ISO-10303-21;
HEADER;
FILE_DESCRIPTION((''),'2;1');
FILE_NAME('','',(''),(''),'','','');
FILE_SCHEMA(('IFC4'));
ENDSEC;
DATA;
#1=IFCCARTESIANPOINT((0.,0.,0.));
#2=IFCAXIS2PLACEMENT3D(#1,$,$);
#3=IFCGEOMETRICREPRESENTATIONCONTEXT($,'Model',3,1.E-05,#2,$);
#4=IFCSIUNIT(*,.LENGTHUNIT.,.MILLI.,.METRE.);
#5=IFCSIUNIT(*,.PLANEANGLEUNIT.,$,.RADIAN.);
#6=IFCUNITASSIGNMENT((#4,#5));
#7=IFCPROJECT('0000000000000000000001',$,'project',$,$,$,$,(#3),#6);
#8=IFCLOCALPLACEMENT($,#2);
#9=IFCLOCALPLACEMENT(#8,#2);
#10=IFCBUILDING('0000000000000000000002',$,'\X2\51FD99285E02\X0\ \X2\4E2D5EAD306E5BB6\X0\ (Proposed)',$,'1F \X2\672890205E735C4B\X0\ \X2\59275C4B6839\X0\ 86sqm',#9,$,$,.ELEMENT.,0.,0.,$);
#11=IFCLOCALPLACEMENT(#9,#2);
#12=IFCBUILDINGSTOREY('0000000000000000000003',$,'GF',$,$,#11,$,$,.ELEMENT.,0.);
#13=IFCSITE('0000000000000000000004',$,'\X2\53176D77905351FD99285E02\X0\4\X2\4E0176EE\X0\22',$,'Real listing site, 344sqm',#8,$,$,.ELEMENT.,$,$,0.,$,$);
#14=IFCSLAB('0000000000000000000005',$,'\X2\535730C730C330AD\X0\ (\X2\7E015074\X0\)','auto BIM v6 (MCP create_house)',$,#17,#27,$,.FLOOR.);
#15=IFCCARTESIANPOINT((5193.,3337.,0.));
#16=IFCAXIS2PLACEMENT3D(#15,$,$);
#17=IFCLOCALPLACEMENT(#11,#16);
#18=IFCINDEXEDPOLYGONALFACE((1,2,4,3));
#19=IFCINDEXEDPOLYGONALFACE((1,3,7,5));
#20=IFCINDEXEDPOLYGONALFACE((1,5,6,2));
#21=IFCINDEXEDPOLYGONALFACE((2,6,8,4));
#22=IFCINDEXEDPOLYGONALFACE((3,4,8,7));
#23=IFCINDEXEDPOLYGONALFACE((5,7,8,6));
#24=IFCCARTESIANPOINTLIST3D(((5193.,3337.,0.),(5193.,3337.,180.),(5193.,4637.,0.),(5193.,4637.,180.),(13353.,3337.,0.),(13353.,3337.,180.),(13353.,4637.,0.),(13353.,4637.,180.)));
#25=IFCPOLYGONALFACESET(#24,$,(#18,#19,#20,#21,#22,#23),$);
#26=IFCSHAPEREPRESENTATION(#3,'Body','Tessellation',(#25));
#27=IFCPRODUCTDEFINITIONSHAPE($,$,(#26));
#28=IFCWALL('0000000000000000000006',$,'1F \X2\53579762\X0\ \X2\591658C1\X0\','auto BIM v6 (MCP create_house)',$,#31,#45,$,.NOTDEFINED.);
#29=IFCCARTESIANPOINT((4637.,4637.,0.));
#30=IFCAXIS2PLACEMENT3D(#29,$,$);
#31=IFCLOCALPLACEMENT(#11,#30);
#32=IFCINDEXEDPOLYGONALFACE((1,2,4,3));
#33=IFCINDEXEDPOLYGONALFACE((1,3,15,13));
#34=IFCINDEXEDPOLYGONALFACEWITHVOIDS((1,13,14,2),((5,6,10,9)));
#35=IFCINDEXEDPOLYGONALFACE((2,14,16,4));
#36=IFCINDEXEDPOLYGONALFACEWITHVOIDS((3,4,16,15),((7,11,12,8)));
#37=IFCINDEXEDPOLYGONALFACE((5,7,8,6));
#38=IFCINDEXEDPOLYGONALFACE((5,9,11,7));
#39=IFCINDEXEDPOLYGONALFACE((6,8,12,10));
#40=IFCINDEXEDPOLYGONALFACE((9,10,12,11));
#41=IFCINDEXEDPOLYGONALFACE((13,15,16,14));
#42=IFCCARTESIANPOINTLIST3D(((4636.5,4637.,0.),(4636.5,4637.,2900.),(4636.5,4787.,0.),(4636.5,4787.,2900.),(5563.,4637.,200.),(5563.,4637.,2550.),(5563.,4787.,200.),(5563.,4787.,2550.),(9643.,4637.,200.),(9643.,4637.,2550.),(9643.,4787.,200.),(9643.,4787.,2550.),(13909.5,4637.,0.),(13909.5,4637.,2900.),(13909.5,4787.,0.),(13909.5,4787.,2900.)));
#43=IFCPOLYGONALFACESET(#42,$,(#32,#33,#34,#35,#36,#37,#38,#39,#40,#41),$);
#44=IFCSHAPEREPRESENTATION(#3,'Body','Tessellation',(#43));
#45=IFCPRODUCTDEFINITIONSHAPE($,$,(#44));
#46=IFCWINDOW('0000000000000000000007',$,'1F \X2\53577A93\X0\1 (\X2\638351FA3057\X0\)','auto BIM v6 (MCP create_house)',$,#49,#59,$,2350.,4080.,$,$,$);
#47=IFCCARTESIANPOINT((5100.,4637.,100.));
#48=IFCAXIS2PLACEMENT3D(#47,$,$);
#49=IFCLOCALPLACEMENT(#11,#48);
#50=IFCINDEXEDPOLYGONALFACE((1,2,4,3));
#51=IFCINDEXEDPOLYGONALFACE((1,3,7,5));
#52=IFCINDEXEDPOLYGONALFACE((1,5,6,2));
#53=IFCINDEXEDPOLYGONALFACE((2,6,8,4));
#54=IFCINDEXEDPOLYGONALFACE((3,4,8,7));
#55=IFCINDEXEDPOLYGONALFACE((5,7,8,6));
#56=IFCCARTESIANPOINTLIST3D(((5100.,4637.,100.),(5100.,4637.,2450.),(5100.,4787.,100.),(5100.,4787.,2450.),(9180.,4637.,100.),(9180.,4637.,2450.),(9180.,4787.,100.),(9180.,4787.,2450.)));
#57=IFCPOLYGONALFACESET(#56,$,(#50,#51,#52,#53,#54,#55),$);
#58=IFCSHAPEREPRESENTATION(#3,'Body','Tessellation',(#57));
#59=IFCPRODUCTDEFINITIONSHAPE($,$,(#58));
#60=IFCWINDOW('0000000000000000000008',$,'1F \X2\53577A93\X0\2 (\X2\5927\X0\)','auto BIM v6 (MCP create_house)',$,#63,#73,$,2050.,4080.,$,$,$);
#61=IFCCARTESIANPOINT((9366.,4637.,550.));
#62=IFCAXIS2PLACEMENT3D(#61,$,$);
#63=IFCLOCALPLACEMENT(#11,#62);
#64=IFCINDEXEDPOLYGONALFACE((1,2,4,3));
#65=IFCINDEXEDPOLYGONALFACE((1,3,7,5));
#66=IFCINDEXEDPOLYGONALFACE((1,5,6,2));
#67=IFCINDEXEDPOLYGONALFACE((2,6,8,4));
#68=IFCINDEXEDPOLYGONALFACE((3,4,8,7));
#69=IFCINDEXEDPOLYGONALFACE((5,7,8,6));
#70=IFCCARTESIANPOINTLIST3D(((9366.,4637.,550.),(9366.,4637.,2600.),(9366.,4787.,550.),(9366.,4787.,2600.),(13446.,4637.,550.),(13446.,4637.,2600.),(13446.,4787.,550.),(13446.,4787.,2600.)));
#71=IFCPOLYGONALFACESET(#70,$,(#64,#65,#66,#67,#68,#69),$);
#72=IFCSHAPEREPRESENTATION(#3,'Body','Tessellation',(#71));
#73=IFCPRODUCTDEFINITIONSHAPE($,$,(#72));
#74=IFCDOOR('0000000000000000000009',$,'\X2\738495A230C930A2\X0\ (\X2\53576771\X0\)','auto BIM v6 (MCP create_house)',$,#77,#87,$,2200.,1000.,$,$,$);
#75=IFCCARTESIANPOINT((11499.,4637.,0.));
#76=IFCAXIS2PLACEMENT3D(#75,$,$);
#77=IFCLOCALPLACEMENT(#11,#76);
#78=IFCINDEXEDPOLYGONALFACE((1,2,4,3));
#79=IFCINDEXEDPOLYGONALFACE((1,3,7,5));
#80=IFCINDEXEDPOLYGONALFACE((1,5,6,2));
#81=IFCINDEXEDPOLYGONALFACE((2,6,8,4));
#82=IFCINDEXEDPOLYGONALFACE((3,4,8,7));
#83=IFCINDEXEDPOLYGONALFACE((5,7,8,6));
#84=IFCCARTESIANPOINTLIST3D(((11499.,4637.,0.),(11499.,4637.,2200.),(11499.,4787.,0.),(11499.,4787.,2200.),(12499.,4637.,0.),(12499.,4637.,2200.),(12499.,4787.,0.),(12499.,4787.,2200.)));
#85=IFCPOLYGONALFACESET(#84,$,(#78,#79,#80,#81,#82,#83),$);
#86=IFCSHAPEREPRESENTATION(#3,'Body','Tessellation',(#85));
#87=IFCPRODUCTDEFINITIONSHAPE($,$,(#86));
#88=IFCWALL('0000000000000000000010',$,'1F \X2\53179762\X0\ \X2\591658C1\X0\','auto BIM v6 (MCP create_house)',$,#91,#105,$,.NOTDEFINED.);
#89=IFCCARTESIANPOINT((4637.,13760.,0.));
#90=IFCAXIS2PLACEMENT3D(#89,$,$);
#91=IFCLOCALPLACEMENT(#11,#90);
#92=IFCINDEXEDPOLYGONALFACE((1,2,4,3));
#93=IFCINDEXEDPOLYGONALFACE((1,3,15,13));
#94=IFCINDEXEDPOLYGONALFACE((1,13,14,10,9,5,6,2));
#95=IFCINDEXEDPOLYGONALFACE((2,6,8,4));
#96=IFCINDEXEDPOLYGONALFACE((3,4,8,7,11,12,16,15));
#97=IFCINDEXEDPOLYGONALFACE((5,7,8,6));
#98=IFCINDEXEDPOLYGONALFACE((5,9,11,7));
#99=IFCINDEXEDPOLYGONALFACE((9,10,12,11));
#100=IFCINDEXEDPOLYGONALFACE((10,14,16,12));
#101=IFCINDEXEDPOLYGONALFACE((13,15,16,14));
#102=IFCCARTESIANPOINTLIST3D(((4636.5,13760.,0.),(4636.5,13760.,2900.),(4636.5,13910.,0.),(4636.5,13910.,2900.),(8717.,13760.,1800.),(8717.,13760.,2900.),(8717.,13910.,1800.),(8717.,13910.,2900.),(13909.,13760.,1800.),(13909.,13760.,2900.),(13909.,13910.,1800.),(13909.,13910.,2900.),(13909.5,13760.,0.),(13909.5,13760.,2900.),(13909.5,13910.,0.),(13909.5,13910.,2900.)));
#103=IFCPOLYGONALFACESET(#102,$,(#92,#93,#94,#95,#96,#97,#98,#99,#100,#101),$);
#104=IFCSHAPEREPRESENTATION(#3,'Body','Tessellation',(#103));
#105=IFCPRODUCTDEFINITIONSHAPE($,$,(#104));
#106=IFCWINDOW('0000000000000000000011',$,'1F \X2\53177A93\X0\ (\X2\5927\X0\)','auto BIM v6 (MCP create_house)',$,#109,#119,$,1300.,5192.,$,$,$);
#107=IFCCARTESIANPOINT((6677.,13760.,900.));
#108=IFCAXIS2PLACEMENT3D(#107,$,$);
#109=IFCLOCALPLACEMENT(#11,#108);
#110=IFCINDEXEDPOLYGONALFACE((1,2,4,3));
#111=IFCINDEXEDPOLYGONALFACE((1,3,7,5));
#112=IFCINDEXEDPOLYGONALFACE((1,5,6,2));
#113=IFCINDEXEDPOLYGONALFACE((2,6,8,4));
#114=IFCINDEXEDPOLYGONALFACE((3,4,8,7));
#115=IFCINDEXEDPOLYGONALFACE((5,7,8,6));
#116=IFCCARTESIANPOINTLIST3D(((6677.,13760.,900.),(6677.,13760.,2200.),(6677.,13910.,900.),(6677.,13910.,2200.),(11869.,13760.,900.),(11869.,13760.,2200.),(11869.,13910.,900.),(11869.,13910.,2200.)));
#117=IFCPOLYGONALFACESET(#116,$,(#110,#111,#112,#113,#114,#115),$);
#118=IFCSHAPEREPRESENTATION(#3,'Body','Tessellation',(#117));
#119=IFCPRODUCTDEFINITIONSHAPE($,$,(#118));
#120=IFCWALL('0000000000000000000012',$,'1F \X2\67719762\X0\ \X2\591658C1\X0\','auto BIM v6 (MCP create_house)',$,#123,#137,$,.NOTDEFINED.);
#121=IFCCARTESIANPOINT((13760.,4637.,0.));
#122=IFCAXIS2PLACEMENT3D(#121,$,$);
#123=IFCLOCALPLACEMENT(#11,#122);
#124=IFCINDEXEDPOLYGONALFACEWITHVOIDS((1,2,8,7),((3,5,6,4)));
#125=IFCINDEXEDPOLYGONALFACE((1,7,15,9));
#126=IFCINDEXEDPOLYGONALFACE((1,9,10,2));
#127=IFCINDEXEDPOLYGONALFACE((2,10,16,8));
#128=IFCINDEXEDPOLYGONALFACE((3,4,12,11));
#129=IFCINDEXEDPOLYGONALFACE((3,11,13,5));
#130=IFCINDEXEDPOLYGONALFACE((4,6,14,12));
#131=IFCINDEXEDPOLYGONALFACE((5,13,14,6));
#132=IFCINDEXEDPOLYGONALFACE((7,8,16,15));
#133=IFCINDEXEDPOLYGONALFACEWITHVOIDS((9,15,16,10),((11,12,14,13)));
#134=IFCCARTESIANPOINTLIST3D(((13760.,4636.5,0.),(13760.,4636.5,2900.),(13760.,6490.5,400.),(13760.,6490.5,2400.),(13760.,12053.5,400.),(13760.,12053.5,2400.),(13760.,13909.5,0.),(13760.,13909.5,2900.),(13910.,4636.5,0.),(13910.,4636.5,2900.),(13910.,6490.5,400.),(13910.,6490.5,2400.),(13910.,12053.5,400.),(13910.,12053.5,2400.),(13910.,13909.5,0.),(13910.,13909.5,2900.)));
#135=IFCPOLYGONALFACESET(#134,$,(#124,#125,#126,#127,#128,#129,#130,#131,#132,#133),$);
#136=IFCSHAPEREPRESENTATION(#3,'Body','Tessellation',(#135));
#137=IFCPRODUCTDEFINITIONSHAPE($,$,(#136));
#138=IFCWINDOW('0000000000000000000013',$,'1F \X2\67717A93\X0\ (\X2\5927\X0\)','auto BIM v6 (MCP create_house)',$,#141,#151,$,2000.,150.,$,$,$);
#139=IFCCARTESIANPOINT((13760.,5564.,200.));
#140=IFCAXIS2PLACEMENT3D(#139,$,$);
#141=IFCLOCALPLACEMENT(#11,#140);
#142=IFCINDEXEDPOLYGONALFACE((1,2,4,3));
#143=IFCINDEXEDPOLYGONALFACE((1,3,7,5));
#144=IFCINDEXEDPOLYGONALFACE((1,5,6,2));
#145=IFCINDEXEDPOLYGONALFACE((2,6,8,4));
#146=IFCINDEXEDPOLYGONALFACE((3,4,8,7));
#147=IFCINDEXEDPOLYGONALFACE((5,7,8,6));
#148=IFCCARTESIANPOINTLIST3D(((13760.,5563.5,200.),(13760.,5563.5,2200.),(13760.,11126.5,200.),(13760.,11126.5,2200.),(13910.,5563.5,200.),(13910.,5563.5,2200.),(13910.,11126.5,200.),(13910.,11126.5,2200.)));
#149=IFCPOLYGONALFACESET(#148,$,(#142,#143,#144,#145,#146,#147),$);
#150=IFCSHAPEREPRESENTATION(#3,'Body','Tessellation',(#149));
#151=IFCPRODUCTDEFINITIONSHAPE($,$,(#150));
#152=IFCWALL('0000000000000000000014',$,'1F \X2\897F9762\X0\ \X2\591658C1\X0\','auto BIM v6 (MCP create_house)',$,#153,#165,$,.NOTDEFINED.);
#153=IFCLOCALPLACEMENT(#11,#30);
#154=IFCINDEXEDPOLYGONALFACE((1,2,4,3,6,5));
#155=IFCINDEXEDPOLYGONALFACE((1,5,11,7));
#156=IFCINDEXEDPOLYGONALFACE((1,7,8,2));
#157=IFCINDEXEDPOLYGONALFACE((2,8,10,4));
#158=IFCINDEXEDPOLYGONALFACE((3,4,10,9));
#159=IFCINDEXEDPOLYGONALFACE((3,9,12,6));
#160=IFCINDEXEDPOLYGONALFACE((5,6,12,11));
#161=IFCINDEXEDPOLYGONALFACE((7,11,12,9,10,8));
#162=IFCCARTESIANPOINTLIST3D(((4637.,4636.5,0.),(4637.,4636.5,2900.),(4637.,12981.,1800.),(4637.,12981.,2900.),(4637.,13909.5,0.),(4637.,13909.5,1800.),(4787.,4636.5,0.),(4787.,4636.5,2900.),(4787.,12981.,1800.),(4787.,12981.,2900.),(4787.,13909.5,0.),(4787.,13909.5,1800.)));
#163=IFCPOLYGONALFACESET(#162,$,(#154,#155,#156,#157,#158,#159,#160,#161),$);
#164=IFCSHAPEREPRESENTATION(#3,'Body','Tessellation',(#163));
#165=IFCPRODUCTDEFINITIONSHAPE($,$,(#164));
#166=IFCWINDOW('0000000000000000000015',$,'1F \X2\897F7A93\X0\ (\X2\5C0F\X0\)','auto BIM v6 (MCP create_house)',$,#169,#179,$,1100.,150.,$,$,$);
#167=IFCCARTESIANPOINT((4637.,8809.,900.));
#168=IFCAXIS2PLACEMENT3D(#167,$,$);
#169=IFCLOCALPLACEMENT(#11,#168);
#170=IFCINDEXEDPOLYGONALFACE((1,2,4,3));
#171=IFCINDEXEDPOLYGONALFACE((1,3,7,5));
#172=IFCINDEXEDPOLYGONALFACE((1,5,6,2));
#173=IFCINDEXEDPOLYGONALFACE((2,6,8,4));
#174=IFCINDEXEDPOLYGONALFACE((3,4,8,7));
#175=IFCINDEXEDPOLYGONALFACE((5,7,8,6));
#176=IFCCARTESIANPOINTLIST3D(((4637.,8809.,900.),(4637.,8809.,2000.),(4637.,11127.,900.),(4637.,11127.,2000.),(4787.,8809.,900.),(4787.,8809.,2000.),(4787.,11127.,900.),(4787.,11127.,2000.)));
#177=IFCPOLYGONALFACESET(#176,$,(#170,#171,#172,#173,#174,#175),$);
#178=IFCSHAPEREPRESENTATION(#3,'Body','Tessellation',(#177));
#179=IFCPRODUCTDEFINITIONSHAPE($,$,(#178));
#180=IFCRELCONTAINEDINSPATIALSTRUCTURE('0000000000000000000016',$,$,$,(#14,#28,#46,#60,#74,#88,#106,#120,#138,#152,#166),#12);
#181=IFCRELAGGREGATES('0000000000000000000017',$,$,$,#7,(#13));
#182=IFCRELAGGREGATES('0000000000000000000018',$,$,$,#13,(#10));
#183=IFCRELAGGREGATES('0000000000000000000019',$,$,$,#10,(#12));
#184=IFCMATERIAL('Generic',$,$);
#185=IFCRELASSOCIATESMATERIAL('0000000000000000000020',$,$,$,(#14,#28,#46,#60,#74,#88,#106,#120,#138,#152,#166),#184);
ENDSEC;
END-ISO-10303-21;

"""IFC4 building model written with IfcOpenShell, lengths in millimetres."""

from ifc_helpers import new_model, si_unit, frame, frame_2d, origin, place, context, project, spatial, rectangle, extrude, material, element, fill, save


model = new_model("IFC4")

# Units and contexts
model_context = context("Model", 3, precision=1e-05, world=origin())
ifc_project = project(units=[si_unit("LENGTHUNIT", "METRE", prefix="MILLI"), si_unit("PLANEANGLEUNIT", "RADIAN")], contexts=[model_context])

# Site, building, storey
site_placement = place(None, origin())
site = spatial("IfcSite", under=ifc_project, at=site_placement, Name="北海道函館市4丁目22", ObjectType="Real listing site, 344sqm", CompositionType="ELEMENT", RefElevation=0.0)
building_placement = place(site_placement, origin())
building = spatial("IfcBuilding", under=site, at=building_placement, Name="函館市 中庭の家 (Proposed)", ObjectType="1F 木造平屋 大屋根 86sqm", CompositionType="ELEMENT", ElevationOfRefHeight=0.0, ElevationOfTerrain=0.0)
storey_placement = place(building_placement, origin())
storey = spatial("IfcBuildingStorey", under=building, at=storey_placement, Name="GF", CompositionType="ELEMENT", Elevation=0.0)

# Slab
ifc_material = material(Name="Generic")
slab_1_placement = place(storey_placement, frame((5193.0, 3337.0, 0.0)))
element("IfcSlab", 1, at=slab_1_placement, inside=storey, material=ifc_material, Name="南デッキ (縁側)", Description="auto BIM v6 (MCP create_house)", PredefinedType="FLOOR", context=model_context, shape_type="SweptSolid", body=[
    extrude(rectangle(XDim=8160.0, YDim=1300.0, at=frame_2d((4080.0, 650.0))), frame((5193.0, 3337.0, 0.0)), (0.0, 0.0, 1.0), 180.0),
])

# Wall, openings, windows, door
wall_1_placement = place(storey_placement, frame((4637.0, 4637.0, 0.0)))
wall_1 = element("IfcWall", 2, at=wall_1_placement, inside=storey, material=ifc_material, Name="1F 南面 外壁", Description="auto BIM v6 (MCP create_house)", PredefinedType="NOTDEFINED", context=model_context, shape_type="SweptSolid", body=[
    extrude(rectangle(XDim=9273.0, YDim=150.0, at=frame_2d((4636.0, 75.0))), frame((4637.0, 4637.0, 0.0)), (0.0, 0.0, 1.0), 2900.0),
])
opening_1_placement = place(storey_placement, frame((5100.0, 4637.0, 100.0)))
opening_1 = element("IfcOpeningElement", 3, at=opening_1_placement, cuts=wall_1, PredefinedType="NOTDEFINED", context=model_context, shape_type="SweptSolid", body=[
    extrude(rectangle(XDim=4080.0, YDim=150.0, at=frame_2d((2040.0, 75.0))), frame((5100.0, 4637.0, 100.0)), (0.0, 0.0, 1.0), 2350.0),
])
opening_2_placement = place(storey_placement, frame((9366.0, 4637.0, 550.0)))
opening_2 = element("IfcOpeningElement", 4, at=opening_2_placement, cuts=wall_1, PredefinedType="NOTDEFINED", context=model_context, shape_type="SweptSolid", body=[
    extrude(rectangle(XDim=4080.0, YDim=150.0, at=frame_2d((2040.0, 75.0))), frame((9366.0, 4637.0, 550.0)), (0.0, 0.0, 1.0), 2050.0),
])
opening_3_placement = place(storey_placement, frame((11499.0, 4637.0, 0.0)))
opening_3 = element("IfcOpeningElement", 5, at=opening_3_placement, cuts=wall_1, PredefinedType="NOTDEFINED", context=model_context, shape_type="SweptSolid", body=[
    extrude(rectangle(XDim=1000.0, YDim=150.0, at=frame_2d((500.0, 75.0))), frame((11499.0, 4637.0, 0.0)), (0.0, 0.0, 1.0), 2200.0),
])
window_1_placement = place(storey_placement, frame((5100.0, 4637.0, 100.0)))
window_1 = element("IfcWindow", 6, at=window_1_placement, inside=storey, material=ifc_material, Name="1F 南窓1 (掃出し)", Description="auto BIM v6 (MCP create_house)", OverallHeight=2350.0, OverallWidth=4080.0, context=model_context, shape_type="SweptSolid", body=[
    extrude(rectangle(XDim=4080.0, YDim=150.0, at=frame_2d((2040.0, 75.0))), frame((5100.0, 4637.0, 100.0)), (0.0, 0.0, 1.0), 2350.0),
])
fill(opening_1, window_1)
window_2_placement = place(storey_placement, frame((9366.0, 4637.0, 550.0)))
window_2 = element("IfcWindow", 7, at=window_2_placement, inside=storey, material=ifc_material, Name="1F 南窓2 (大)", Description="auto BIM v6 (MCP create_house)", OverallHeight=2050.0, OverallWidth=4080.0, context=model_context, shape_type="SweptSolid", body=[
    extrude(rectangle(XDim=4080.0, YDim=150.0, at=frame_2d((2040.0, 75.0))), frame((9366.0, 4637.0, 550.0)), (0.0, 0.0, 1.0), 2050.0),
])
fill(opening_2, window_2)
door_placement = place(storey_placement, frame((11499.0, 4637.0, 0.0)))
door = element("IfcDoor", 8, at=door_placement, inside=storey, material=ifc_material, Name="玄関ドア (南東)", Description="auto BIM v6 (MCP create_house)", OverallHeight=2200.0, OverallWidth=1000.0, context=model_context, shape_type="SweptSolid", body=[
    extrude(rectangle(XDim=1000.0, YDim=150.0, at=frame_2d((500.0, 75.0))), frame((11499.0, 4637.0, 0.0)), (0.0, 0.0, 1.0), 2200.0),
])
fill(opening_3, door)

# Walls, openings, windows
wall_2_placement = place(storey_placement, frame((4637.0, 13760.0, 0.0)))
wall_2 = element("IfcWall", 9, at=wall_2_placement, inside=storey, material=ifc_material, Name="1F 北面 外壁", Description="auto BIM v6 (MCP create_house)", PredefinedType="NOTDEFINED", context=model_context, shape_type="SweptSolid", body=[
    extrude(rectangle(XDim=9273.0, YDim=150.0, at=frame_2d((4636.0, 75.0))), frame((4637.0, 13760.0, 0.0)), (0.0, 0.0, 1.0), 2900.0),
])
opening_4_placement = place(storey_placement, frame((6677.0, 13760.0, 900.0)))
opening_4 = element("IfcOpeningElement", 10, at=opening_4_placement, cuts=wall_2, PredefinedType="NOTDEFINED", context=model_context, shape_type="SweptSolid", body=[
    extrude(rectangle(XDim=5192.0, YDim=150.0, at=frame_2d((2596.0, 75.0))), frame((6677.0, 13760.0, 900.0)), (0.0, 0.0, 1.0), 1300.0),
])
window_3_placement = place(storey_placement, frame((6677.0, 13760.0, 900.0)))
window_3 = element("IfcWindow", 11, at=window_3_placement, inside=storey, material=ifc_material, Name="1F 北窓 (大)", Description="auto BIM v6 (MCP create_house)", OverallHeight=1300.0, OverallWidth=5192.0, context=model_context, shape_type="SweptSolid", body=[
    extrude(rectangle(XDim=5192.0, YDim=150.0, at=frame_2d((2596.0, 75.0))), frame((6677.0, 13760.0, 900.0)), (0.0, 0.0, 1.0), 1300.0),
])
fill(opening_4, window_3)
wall_3_placement = place(storey_placement, frame((13760.0, 4637.0, 0.0)))
wall_3 = element("IfcWall", 12, at=wall_3_placement, inside=storey, material=ifc_material, Name="1F 東面 外壁", Description="auto BIM v6 (MCP create_house)", PredefinedType="NOTDEFINED", context=model_context, shape_type="SweptSolid", body=[
    extrude(rectangle(XDim=150.0, YDim=9273.0, at=frame_2d((75.0, 4636.0))), frame((13760.0, 4637.0, 0.0)), (0.0, 0.0, 1.0), 2900.0),
])
opening_5_placement = place(storey_placement, frame((13760.0, 5564.0, 200.0)))
opening_5 = element("IfcOpeningElement", 13, at=opening_5_placement, cuts=wall_3, PredefinedType="NOTDEFINED", context=model_context, shape_type="SweptSolid", body=[
    extrude(rectangle(XDim=150.0, YDim=5563.0, at=frame_2d((75.0, 2781.0))), frame((13760.0, 5564.0, 200.0)), (0.0, 0.0, 1.0), 2000.0),
])
window_4_placement = place(storey_placement, frame((13760.0, 5564.0, 200.0)))
window_4 = element("IfcWindow", 14, at=window_4_placement, inside=storey, material=ifc_material, Name="1F 東窓 (大)", Description="auto BIM v6 (MCP create_house)", OverallHeight=2000.0, OverallWidth=150.0, context=model_context, shape_type="SweptSolid", body=[
    extrude(rectangle(XDim=150.0, YDim=5563.0, at=frame_2d((75.0, 2781.0))), frame((13760.0, 5564.0, 200.0)), (0.0, 0.0, 1.0), 2000.0),
])
fill(opening_5, window_4)
wall_4_placement = place(storey_placement, frame((4637.0, 4637.0, 0.0)))
wall_4 = element("IfcWall", 15, at=wall_4_placement, inside=storey, material=ifc_material, Name="1F 西面 外壁", Description="auto BIM v6 (MCP create_house)", PredefinedType="NOTDEFINED", context=model_context, shape_type="SweptSolid", body=[
    extrude(rectangle(XDim=150.0, YDim=9273.0, at=frame_2d((75.0, 4636.0))), frame((4637.0, 4637.0, 0.0)), (0.0, 0.0, 1.0), 2900.0),
])
opening_6_placement = place(storey_placement, frame((4637.0, 8809.0, 900.0)))
opening_6 = element("IfcOpeningElement", 16, at=opening_6_placement, cuts=wall_4, PredefinedType="NOTDEFINED", context=model_context, shape_type="SweptSolid", body=[
    extrude(rectangle(XDim=150.0, YDim=2318.0, at=frame_2d((75.0, 1159.0))), frame((4637.0, 8809.0, 900.0)), (0.0, 0.0, 1.0), 1100.0),
])
window_5_placement = place(storey_placement, frame((4637.0, 8809.0, 900.0)))
window_5 = element("IfcWindow", 17, at=window_5_placement, inside=storey, material=ifc_material, Name="1F 西窓 (小)", Description="auto BIM v6 (MCP create_house)", OverallHeight=1100.0, OverallWidth=150.0, context=model_context, shape_type="SweptSolid", body=[
    extrude(rectangle(XDim=150.0, YDim=2318.0, at=frame_2d((75.0, 1159.0))), frame((4637.0, 8809.0, 900.0)), (0.0, 0.0, 1.0), 1100.0),
])
fill(opening_6, window_5)

save(model, "model.ifc")
